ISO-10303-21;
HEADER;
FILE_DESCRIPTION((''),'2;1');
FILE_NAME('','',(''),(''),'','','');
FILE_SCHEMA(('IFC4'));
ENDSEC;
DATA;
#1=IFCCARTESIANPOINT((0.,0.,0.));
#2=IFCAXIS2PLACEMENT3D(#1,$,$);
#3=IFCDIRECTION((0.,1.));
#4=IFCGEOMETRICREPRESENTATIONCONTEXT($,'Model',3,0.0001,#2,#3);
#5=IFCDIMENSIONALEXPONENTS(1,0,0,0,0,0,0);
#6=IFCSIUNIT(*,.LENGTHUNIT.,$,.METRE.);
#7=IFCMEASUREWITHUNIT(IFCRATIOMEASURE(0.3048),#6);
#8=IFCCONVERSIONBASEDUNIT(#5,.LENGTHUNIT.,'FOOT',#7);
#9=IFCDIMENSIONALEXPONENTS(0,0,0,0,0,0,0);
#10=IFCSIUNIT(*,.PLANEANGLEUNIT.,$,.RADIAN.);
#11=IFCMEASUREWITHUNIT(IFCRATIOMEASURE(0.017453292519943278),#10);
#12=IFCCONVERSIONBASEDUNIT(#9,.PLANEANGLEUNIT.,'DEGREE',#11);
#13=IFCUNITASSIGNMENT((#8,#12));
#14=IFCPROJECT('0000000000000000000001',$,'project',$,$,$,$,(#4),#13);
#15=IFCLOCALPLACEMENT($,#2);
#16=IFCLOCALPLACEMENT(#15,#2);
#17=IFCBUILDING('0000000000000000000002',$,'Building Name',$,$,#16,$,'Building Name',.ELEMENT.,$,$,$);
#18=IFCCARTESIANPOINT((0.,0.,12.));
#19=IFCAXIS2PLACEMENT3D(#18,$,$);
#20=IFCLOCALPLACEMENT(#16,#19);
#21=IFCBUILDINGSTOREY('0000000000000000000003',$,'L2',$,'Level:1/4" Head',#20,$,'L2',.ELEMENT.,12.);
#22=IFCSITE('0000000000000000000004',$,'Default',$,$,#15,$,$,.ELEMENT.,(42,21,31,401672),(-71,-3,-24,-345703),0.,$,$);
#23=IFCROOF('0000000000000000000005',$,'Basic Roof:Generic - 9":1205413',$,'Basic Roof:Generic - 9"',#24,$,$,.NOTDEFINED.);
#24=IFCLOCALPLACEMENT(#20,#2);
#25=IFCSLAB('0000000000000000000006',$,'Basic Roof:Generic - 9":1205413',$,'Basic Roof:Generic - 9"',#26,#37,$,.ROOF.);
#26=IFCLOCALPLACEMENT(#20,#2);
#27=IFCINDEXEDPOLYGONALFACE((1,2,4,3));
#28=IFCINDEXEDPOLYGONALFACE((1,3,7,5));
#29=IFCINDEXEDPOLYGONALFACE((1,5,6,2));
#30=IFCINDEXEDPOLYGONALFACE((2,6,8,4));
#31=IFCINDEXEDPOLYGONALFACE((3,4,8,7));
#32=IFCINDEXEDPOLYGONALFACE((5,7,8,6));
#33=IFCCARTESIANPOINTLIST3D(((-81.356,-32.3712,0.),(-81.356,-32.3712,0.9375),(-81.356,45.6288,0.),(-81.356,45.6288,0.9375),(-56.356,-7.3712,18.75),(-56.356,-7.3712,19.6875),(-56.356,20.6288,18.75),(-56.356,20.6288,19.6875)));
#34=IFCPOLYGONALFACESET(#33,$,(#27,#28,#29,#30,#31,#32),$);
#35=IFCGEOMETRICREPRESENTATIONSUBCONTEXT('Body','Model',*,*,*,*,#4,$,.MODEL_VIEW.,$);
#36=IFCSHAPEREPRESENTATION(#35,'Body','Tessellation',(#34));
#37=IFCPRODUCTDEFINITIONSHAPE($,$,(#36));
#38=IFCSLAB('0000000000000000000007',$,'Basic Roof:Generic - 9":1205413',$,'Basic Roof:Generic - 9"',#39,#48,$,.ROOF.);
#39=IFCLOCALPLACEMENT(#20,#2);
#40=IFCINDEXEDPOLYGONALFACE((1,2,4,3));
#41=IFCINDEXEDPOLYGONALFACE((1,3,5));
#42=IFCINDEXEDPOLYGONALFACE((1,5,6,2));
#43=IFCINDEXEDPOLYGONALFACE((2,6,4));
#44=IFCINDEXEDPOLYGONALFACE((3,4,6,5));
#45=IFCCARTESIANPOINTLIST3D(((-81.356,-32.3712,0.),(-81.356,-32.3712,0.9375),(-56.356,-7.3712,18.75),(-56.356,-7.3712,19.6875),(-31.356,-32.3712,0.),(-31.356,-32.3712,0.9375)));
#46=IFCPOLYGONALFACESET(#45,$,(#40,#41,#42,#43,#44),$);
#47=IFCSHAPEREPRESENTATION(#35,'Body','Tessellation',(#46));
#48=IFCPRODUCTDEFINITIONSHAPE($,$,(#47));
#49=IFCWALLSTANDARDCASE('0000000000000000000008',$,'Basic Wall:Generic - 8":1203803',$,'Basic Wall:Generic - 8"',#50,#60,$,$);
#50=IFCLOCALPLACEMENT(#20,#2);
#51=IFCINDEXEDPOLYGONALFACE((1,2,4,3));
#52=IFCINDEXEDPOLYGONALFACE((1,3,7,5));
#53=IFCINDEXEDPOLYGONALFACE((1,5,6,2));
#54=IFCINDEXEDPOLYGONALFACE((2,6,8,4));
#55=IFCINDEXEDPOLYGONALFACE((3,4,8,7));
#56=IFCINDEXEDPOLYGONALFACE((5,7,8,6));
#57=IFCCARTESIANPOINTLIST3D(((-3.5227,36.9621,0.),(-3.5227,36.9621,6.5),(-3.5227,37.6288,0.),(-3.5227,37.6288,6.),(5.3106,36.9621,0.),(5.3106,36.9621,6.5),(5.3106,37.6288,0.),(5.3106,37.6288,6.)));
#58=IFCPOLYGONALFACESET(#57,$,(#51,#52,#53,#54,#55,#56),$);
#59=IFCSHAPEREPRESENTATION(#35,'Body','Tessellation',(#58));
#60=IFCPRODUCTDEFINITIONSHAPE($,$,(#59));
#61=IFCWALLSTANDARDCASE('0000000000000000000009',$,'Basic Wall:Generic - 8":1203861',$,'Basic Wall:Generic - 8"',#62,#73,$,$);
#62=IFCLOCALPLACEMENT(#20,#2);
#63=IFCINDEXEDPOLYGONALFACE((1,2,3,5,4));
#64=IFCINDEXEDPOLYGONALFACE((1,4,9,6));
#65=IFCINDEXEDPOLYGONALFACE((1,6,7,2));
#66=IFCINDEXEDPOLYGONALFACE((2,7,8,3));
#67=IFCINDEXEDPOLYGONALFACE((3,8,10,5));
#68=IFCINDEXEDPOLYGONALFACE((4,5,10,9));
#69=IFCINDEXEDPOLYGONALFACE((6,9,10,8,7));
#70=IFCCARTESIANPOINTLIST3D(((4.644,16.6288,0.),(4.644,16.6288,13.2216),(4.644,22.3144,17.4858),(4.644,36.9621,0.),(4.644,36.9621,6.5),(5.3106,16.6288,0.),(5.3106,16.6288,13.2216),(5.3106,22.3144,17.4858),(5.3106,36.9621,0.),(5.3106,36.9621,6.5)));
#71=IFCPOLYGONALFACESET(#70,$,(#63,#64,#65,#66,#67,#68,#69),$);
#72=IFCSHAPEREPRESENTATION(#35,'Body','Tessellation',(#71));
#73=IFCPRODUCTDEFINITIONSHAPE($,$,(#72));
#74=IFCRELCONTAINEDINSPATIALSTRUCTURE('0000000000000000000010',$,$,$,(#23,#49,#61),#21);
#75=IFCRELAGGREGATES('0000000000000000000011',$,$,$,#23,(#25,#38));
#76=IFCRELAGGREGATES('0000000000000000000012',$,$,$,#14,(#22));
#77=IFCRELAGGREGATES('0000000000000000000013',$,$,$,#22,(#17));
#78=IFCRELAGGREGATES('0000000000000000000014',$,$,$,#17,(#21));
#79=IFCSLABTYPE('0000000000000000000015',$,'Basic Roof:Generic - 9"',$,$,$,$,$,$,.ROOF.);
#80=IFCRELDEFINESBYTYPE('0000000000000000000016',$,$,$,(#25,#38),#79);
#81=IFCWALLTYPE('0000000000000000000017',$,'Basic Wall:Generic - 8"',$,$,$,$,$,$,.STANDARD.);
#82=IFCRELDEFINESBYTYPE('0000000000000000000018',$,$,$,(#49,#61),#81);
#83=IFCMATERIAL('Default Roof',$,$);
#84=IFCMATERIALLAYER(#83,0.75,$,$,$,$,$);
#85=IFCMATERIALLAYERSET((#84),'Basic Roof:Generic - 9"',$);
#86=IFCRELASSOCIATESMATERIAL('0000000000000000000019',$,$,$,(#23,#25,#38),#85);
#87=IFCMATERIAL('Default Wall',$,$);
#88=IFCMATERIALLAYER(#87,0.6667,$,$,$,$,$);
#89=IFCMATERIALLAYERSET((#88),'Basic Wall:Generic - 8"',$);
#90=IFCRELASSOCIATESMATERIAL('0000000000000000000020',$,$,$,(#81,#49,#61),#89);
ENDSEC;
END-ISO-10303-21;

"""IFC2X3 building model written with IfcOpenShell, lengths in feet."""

from ifc_helpers import new_model, entity, si_unit, converted_unit, direction, frame, frame_2d, origin, place, context, subcontext, project, spatial, polyline, rectangle, outline, extrude, clip, bounded_halfspace, material, layer, layer_set, layer_usage, type_object, element, aggregate, save


model = new_model("IFC2X3")

# Units and contexts
model_context = context("Model", 3, precision=0.0001, world=origin(), true_north=direction((0.0, 1.0)))
body_context = subcontext(model_context, "Body", "Model", "MODEL_VIEW")
ifc_project = project(units=[converted_unit("LENGTHUNIT", "FOOT", entity("IfcRatioMeasure", 0.3048), si_unit("LENGTHUNIT", "METRE"), dimensions=[1, 0, 0, 0, 0, 0, 0]), converted_unit("PLANEANGLEUNIT", "DEGREE", entity("IfcRatioMeasure", 0.017453292519943278), si_unit("PLANEANGLEUNIT", "RADIAN"), dimensions=[0, 0, 0, 0, 0, 0, 0])], contexts=[model_context])

# Site, building, storey
site_placement = place(None, origin())
site = spatial("IfcSite", under=ifc_project, at=site_placement, Name="Default", CompositionType="ELEMENT", RefLatitude=(42, 21, 31, 401672), RefLongitude=(-71, -3, -24, -345703), RefElevation=0.0)
building_placement = place(site_placement, origin())
building = spatial("IfcBuilding", under=site, at=building_placement, Name="Building Name", LongName="Building Name", CompositionType="ELEMENT")
storey_placement = place(building_placement, frame((0.0, 0.0, 12.0)))
storey = spatial("IfcBuildingStorey", under=building, at=storey_placement, Name="L2", ObjectType="Level:1/4\" Head", LongName="L2", CompositionType="ELEMENT", Elevation=12.0)

# Roof, slabs
ifc_material_1 = material(Name="Default Roof")
ifc_layer_1 = layer(ifc_material_1, 0.75)
ifc_layer_set_1 = layer_set([ifc_layer_1], Name="Basic Roof:Generic - 9\"")
roof_placement = place(storey_placement, frame((-81.356, -32.3712, 0.0)))
roof = element("IfcRoof", 1, at=roof_placement, inside=storey, material=ifc_layer_set_1, Name="Basic Roof:Generic - 9\":1205413", ObjectType="Basic Roof:Generic - 9\"", ShapeType="NOTDEFINED")
slab_type_1 = type_object("IfcSlabType", Name="Basic Roof:Generic - 9\"", PredefinedType="ROOF")
slab_1_placement = place(roof_placement, origin())
slab_1 = element("IfcSlab", 2, at=slab_1_placement, type_object=slab_type_1, material=ifc_layer_set_1, Name="Basic Roof:Generic - 9\":1205413", ObjectType="Basic Roof:Generic - 9\"", PredefinedType="ROOF", context=body_context, shape_type="SweptSolid", body=[
    extrude(outline(polyline([(15.625, -14.0), (15.625, 14.0), (-15.625, 39.0), (-15.625, -39.0), (15.625, -14.0)])), frame((12.5, 39.0, 9.375), z_axis=(-0.6, 0.0, 0.8), x_axis=(0.8, 0.0, 0.6)), (0.6, 0.0, 0.8), 0.9375),
])
slab_2_placement = place(roof_placement, origin())
slab_2 = element("IfcSlab", 3, at=slab_2_placement, type_object=slab_type_1, material=ifc_layer_set_1, Name="Basic Roof:Generic - 9\":1205413", ObjectType="Basic Roof:Generic - 9\"", PredefinedType="ROOF", context=body_context, shape_type="SweptSolid", body=[
    extrude(outline(polyline([(-25.0, -15.625), (25.0, -15.625), (0.0, 15.625), (-25.0, -15.625)])), frame((25.0, 12.5, 9.375), z_axis=(0.0, -0.6, 0.8), x_axis=(1.0, 0.0, 0.0)), (0.0, 0.6, 0.8), 0.9375),
])
aggregate(roof, [slab_1, slab_2])

# Walls
ifc_material_2 = material(Name="Default Wall")
ifc_layer_2 = layer(ifc_material_2, 0.6667)
ifc_layer_set_2 = layer_set([ifc_layer_2], Name="Basic Wall:Generic - 8\"")
ifc_layer_usage_1 = layer_usage(ifc_layer_set_2, "AXIS2", "NEGATIVE", 0.3333)
wall_type = type_object("IfcWallType", Name="Basic Wall:Generic - 8\"", PredefinedType="STANDARD", material=ifc_layer_set_2)
wall_1_placement = place(storey_placement, frame((-3.5227, 37.2955, 0.0)))
element("IfcWallStandardCase", 4, at=wall_1_placement, inside=storey, type_object=wall_type, material=ifc_layer_usage_1, Name="Basic Wall:Generic - 8\":1203803", ObjectType="Basic Wall:Generic - 8\"", context=body_context, shape_type="Clipping", body=[
    clip(extrude(rectangle(XDim=8.8333, YDim=0.6667, at=frame_2d((4.4167, 0.0), x_axis=(-1.0, 0.0))), origin(), (0.0, 0.0, 1.0), 6.5), bounded_halfspace(frame((0.0, -0.3333, 6.5), z_axis=(0.0, 0.6, 0.8), x_axis=(-1.0, 0.0, 0.0)), False, frame((0.0, -0.3333, 6.5)), polyline([(0.0, 0.0), (8.1667, 0.0), (8.8333, 0.0), (8.8333, 0.6667), (0.0, 0.6667), (0.0, 0.0)]))),
])
wall_2_placement = place(storey_placement, frame((4.9773, 36.9621, 0.0), z_axis=(0.0, 0.0, 1.0), x_axis=(0.0, -1.0, 0.0)))
element("IfcWallStandardCase", 5, at=wall_2_placement, inside=storey, type_object=wall_type, material=ifc_layer_usage_1, Name="Basic Wall:Generic - 8\":1203861", ObjectType="Basic Wall:Generic - 8\"", context=body_context, shape_type="Clipping", body=[
    clip(clip(extrude(rectangle(XDim=20.3333, YDim=0.6667, at=frame_2d((10.1667, 0.0), x_axis=(-1.0, 0.0))), origin(), (0.0, 0.0, 1.0), 17.4858), bounded_halfspace(frame((14.6477, -0.3333, 17.4858), z_axis=(0.6, 0.0, 0.8), x_axis=(0.0, 1.0, 0.0)), False, frame((14.6477, -0.3333, 17.4858)), polyline([(0.0, 0.0), (5.6856, 0.0), (5.6856, 0.6667), (0.0, 0.6667), (0.0, 0.0)]))), bounded_halfspace(frame((0.0, -0.3333, 6.5), z_axis=(-0.6, 0.0, 0.8), x_axis=(0.0, -1.0, 0.0)), False, frame((0.0, -0.3333, 6.5)), polyline([(0.0, 0.0), (14.6477, 0.0), (14.6477, 0.6667), (0.0, 0.6667), (0.0, 0.0)]))),
])

save(model, "model.ifc")
